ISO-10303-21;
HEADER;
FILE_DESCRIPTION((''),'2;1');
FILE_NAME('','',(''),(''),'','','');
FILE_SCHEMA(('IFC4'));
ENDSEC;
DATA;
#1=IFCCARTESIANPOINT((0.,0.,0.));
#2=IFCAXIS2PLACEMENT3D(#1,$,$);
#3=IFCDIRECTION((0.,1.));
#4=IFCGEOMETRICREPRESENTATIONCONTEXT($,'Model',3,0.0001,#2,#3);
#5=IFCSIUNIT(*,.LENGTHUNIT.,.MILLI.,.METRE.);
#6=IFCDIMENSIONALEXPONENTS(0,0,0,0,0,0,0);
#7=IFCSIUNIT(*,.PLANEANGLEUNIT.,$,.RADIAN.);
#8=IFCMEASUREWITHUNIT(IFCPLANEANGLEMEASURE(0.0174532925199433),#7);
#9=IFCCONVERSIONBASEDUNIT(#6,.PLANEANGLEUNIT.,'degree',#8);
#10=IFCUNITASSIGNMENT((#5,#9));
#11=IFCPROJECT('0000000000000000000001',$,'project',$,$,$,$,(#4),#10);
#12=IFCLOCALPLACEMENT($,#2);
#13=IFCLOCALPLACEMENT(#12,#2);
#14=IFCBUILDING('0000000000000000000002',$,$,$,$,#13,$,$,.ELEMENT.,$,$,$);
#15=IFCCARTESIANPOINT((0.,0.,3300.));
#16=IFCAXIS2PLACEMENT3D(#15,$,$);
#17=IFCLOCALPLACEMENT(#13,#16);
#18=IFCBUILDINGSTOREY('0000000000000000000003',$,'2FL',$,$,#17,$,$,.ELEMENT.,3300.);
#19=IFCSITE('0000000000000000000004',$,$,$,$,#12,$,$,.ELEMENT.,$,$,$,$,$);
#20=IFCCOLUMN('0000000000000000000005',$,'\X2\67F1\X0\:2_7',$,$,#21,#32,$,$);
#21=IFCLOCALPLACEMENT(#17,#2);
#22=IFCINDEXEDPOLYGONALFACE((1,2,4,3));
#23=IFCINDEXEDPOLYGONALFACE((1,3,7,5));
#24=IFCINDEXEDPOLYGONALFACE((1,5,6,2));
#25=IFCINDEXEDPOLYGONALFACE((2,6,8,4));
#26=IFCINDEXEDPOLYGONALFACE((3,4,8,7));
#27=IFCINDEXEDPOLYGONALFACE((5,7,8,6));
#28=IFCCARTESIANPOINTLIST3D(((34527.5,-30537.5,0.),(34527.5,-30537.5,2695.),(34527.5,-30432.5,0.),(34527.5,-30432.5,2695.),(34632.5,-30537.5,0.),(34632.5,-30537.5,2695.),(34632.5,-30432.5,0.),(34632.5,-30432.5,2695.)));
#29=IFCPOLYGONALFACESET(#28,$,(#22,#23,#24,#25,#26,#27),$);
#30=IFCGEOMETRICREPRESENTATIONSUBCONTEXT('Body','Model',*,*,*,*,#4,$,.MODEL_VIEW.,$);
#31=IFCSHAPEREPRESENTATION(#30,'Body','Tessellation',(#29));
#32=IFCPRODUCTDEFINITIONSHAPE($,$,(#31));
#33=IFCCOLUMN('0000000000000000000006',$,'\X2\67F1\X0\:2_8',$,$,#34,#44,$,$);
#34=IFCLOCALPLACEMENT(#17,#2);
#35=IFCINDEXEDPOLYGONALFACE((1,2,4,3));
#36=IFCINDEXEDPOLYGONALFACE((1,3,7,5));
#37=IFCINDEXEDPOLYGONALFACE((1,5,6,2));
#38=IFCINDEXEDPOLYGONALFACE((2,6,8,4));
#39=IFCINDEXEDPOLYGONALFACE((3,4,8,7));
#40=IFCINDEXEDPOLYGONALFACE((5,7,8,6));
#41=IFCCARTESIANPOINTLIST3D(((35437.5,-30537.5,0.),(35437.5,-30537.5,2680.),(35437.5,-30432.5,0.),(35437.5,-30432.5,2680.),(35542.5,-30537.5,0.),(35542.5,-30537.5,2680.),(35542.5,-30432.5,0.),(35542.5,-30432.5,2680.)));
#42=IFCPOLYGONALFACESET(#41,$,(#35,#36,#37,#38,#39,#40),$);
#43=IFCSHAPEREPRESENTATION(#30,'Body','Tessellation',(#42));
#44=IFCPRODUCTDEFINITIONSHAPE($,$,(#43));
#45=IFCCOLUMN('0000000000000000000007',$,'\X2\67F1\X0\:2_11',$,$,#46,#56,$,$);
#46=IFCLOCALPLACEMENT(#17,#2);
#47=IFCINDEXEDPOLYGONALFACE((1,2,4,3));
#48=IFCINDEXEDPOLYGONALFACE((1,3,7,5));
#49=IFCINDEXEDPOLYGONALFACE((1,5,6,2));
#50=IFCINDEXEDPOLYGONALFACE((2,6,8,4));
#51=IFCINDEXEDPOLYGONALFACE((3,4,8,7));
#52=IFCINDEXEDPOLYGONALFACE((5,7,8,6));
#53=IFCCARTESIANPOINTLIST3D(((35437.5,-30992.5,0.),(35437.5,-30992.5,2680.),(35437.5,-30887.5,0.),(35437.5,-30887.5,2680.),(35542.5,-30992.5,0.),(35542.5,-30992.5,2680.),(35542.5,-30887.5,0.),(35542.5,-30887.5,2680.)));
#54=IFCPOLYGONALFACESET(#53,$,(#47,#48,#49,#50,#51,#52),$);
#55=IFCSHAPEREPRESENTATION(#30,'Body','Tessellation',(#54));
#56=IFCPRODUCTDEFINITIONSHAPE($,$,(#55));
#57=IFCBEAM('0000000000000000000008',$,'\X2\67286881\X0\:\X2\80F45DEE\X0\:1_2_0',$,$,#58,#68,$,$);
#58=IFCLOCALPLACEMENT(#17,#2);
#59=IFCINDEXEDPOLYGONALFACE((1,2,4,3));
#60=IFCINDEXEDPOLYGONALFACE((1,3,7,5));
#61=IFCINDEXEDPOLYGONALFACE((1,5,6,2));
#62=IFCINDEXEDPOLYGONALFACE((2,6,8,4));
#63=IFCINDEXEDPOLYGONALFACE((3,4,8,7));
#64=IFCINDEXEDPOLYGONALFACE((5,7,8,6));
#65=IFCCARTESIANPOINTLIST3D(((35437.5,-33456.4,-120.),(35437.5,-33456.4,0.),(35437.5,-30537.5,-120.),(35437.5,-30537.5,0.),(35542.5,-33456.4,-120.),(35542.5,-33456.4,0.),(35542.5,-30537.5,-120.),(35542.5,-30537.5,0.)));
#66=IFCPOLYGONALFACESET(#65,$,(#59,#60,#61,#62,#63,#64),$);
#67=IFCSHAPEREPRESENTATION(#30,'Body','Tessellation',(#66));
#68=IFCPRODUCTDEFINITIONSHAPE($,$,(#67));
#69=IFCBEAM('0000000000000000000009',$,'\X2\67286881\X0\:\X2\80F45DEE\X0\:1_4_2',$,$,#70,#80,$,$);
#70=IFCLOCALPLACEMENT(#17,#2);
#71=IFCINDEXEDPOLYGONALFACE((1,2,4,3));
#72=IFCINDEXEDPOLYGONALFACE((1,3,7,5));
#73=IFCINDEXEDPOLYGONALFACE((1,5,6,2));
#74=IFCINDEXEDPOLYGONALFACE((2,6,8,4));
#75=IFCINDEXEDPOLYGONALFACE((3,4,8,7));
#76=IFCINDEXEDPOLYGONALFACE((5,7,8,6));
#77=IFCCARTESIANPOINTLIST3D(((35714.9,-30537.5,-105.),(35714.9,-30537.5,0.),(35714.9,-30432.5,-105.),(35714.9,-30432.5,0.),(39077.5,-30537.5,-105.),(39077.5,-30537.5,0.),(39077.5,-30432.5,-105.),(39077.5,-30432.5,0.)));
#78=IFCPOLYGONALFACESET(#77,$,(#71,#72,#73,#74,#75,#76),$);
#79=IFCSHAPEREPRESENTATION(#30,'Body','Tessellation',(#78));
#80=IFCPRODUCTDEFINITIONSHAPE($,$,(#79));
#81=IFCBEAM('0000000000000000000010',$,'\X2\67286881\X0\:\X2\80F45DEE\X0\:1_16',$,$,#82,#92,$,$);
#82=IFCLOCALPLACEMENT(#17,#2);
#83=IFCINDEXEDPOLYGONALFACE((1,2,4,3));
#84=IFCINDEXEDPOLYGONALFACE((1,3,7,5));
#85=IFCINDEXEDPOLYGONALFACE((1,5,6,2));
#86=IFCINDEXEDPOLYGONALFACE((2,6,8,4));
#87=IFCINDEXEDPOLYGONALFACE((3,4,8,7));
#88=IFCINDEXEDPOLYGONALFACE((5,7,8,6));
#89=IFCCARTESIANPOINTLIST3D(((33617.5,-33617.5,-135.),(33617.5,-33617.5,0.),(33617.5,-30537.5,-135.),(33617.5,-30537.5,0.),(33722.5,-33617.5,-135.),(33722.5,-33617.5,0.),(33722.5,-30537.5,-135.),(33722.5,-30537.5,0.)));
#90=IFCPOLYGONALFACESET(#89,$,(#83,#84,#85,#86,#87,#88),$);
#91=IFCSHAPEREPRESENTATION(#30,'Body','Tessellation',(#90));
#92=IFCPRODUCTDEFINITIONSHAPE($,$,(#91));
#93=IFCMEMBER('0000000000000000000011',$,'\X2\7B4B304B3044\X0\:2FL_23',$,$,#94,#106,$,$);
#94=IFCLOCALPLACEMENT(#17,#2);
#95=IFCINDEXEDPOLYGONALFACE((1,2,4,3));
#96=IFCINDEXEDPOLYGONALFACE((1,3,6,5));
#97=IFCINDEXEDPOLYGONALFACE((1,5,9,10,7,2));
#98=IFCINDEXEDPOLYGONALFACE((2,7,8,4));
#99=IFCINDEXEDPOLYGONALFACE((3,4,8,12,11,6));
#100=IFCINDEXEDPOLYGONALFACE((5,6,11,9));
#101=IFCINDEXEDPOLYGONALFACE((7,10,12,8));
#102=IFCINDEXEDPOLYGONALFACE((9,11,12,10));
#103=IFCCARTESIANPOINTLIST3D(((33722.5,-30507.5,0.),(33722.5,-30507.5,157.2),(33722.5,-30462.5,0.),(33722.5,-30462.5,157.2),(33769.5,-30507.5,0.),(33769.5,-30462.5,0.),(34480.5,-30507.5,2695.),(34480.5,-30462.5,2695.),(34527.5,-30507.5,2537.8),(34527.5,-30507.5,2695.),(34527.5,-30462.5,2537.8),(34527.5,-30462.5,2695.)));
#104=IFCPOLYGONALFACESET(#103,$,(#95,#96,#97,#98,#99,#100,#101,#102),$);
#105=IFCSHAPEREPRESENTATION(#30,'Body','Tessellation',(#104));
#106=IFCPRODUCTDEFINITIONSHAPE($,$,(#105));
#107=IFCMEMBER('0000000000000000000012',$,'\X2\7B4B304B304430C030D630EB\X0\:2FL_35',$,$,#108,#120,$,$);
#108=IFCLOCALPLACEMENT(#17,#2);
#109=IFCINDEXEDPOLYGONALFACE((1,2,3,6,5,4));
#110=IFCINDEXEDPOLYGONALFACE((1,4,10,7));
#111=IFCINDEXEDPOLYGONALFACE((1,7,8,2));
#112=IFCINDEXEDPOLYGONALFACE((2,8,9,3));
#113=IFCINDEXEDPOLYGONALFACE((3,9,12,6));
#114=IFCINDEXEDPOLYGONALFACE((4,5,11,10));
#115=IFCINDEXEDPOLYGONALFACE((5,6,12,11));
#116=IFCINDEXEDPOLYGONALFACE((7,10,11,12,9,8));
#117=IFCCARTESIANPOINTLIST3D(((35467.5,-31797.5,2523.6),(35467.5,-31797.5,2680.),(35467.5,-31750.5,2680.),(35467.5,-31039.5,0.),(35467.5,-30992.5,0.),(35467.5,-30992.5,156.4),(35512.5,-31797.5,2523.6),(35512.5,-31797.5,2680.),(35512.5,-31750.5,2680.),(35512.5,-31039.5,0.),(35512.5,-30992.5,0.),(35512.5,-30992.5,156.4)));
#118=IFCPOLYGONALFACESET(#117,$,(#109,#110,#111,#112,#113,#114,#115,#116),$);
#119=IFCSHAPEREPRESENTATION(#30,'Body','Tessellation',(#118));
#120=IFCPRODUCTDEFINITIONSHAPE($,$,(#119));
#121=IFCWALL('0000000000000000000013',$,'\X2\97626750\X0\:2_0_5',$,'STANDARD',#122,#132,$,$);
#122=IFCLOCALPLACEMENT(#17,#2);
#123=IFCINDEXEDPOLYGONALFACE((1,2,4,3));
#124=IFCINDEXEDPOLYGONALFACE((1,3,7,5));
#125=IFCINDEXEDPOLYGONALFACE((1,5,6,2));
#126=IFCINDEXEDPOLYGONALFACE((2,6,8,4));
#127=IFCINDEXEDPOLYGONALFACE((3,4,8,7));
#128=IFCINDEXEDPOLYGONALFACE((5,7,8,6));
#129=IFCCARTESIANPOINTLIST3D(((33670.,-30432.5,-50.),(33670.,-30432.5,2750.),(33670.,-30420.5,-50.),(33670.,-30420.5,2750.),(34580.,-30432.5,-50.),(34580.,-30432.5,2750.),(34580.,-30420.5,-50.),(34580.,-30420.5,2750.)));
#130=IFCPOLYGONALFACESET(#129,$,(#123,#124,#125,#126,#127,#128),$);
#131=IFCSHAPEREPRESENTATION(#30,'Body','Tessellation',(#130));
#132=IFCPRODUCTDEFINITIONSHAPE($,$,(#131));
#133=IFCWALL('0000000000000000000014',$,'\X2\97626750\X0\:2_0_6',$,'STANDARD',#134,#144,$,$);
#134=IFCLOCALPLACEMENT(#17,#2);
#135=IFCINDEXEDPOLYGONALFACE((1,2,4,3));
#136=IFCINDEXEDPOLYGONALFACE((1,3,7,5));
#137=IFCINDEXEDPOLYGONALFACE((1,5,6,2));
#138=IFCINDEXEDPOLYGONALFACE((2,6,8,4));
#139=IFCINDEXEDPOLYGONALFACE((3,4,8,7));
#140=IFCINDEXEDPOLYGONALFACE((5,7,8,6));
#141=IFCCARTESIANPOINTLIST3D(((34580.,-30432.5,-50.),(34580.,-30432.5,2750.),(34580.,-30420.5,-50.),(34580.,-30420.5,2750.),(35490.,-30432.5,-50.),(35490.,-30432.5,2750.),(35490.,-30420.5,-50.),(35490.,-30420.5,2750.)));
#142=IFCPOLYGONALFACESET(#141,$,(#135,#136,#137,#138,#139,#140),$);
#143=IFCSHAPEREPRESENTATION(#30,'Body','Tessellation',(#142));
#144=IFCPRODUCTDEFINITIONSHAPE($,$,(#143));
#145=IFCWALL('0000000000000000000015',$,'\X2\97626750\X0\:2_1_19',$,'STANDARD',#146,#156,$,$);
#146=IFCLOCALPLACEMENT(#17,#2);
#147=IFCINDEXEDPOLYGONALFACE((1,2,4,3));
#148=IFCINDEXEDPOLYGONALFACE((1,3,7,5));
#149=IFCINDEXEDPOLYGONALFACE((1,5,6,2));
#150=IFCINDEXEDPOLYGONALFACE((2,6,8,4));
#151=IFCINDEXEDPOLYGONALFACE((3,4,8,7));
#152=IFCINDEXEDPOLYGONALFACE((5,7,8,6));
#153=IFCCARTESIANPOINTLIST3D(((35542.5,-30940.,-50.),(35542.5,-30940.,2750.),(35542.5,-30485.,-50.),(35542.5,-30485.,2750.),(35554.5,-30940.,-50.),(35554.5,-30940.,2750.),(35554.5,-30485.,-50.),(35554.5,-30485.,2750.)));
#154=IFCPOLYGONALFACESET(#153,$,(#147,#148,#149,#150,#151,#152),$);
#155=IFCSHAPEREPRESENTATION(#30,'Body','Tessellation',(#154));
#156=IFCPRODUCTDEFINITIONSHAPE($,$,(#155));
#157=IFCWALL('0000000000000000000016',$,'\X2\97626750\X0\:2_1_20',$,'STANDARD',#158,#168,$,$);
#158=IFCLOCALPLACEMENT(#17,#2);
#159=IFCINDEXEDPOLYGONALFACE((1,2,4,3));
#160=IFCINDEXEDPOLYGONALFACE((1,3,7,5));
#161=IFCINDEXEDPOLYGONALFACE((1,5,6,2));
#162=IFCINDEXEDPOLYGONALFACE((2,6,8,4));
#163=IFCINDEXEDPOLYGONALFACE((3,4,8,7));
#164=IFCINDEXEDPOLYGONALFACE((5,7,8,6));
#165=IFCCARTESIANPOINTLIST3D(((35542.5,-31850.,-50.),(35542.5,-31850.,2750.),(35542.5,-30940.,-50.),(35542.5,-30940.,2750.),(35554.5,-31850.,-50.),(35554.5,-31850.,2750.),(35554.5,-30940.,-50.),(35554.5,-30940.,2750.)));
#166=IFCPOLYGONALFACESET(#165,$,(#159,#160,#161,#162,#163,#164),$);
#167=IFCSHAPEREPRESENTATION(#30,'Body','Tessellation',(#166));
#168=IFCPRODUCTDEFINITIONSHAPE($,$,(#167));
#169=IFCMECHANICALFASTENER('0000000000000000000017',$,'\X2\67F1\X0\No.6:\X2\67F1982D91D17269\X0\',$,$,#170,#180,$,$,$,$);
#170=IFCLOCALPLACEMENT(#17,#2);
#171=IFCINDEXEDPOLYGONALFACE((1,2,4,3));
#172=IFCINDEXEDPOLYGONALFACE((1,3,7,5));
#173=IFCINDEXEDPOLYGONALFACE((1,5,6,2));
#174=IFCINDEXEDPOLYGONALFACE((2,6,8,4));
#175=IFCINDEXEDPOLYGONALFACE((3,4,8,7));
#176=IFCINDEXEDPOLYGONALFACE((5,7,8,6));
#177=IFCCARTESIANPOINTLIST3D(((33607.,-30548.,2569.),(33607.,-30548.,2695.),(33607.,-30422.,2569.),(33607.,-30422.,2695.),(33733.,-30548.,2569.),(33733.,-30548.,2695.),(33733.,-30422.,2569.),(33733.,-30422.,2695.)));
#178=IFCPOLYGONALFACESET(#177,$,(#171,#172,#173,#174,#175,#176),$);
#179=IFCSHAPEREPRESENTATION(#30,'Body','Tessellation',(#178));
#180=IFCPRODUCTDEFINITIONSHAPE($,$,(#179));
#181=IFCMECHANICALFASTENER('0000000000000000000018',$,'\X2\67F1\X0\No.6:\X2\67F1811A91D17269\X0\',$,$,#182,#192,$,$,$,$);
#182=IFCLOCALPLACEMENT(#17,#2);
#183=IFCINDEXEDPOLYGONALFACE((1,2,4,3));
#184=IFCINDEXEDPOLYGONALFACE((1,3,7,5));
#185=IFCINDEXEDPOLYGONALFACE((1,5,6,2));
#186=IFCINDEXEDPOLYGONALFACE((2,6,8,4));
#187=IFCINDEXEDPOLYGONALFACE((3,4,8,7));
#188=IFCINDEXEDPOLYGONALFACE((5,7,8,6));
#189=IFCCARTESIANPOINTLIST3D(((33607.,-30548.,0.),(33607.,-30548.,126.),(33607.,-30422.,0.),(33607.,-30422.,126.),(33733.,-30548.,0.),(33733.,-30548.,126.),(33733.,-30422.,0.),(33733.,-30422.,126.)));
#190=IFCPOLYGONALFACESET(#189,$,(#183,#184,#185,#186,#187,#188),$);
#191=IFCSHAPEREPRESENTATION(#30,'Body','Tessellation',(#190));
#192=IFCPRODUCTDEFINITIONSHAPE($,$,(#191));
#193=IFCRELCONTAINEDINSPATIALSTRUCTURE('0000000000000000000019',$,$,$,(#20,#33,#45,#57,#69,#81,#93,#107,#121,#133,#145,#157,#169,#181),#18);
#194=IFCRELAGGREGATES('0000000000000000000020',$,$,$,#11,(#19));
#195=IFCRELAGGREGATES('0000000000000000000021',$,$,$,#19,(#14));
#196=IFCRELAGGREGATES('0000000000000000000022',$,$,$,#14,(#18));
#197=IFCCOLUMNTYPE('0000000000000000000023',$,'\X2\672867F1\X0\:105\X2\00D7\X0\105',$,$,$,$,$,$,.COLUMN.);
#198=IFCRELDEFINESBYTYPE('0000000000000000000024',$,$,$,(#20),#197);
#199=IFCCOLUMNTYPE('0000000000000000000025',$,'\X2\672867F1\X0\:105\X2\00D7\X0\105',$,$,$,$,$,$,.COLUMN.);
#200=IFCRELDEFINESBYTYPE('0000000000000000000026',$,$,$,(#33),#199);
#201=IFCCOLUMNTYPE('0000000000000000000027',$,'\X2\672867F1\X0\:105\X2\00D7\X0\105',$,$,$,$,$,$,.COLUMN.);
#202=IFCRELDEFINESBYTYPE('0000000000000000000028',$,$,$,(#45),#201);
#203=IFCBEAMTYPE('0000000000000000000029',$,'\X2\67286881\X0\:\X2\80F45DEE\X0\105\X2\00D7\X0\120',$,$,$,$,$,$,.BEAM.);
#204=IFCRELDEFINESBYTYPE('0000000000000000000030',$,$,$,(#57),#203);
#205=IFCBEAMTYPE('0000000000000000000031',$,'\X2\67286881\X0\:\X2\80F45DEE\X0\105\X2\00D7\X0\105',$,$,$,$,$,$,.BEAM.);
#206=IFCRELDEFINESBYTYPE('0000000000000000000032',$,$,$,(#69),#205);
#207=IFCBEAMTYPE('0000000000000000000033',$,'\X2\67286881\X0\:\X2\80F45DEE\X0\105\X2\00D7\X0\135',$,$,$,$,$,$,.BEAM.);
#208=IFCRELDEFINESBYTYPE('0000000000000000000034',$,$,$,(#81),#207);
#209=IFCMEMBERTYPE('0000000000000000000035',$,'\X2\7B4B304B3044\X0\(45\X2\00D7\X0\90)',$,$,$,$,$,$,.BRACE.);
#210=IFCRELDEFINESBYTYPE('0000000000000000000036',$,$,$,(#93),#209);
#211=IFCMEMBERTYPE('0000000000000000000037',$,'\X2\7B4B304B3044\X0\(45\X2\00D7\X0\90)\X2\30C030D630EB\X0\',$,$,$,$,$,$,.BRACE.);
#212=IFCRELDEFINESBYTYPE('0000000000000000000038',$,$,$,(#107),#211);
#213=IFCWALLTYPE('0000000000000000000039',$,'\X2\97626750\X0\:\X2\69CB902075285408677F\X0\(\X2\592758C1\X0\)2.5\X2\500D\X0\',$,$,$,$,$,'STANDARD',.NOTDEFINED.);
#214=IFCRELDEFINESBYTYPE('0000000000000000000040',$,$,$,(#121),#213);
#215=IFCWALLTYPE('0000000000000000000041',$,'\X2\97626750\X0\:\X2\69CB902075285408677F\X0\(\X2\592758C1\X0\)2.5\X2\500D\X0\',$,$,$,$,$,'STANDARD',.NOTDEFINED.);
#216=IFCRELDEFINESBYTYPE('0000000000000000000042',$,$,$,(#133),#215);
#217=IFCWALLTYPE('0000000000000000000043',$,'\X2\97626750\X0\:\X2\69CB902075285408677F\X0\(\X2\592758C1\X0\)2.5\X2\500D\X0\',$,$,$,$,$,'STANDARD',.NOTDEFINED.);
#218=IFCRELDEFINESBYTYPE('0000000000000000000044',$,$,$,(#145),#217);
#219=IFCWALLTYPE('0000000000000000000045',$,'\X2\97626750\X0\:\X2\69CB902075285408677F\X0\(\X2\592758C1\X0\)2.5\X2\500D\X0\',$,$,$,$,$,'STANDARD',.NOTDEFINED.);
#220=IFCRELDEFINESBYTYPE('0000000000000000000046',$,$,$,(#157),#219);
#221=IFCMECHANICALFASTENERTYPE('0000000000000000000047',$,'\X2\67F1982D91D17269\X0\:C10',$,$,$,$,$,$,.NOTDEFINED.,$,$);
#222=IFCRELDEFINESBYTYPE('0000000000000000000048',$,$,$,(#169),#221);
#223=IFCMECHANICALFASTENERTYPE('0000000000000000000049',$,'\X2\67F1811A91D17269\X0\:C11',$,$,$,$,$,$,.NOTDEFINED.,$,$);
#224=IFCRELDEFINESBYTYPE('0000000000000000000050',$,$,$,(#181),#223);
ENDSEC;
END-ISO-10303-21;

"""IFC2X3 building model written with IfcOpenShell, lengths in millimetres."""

from ifc_helpers import new_model, entity, si_unit, converted_unit, direction, frame, origin, origin_with_axes, origin_2d, place, context, subcontext, project, spatial, polyline, rectangle, outline, extrude, type_object, element, save


model = new_model("IFC2X3")

# Units and contexts
model_context = context("Model", 3, precision=0.0001, world=origin(), true_north=direction((0.0, 1.0)))
body_context = subcontext(model_context, "Body", "Model", "MODEL_VIEW")
ifc_project = project(units=[si_unit("LENGTHUNIT", "METRE", prefix="MILLI"), converted_unit("PLANEANGLEUNIT", "degree", entity("IfcPlaneAngleMeasure", 0.0174532925199433), si_unit("PLANEANGLEUNIT", "RADIAN"), dimensions=[0, 0, 0, 0, 0, 0, 0])], contexts=[model_context])

# Site, building, storey
site_placement = place(None, origin())
site = spatial("IfcSite", under=ifc_project, at=site_placement, CompositionType="ELEMENT")
building_placement = place(site_placement, origin())
building = spatial("IfcBuilding", under=site, at=building_placement, CompositionType="ELEMENT")
storey_placement = place(building_placement, frame((0.0, 0.0, 3300.0)))
storey = spatial("IfcBuildingStorey", under=building, at=storey_placement, Name="2FL", CompositionType="ELEMENT", Elevation=3300.0)

# Columns
column_type_1 = type_object("IfcColumnType", Name="木柱:105×105", PredefinedType="COLUMN")
column_1_placement = place(storey_placement, frame((34580.0, -30485.0, 0.0)))
element("IfcColumn", 1, at=column_1_placement, inside=storey, type_object=column_type_1, Name="柱:2_7", context=body_context, shape_type="SweptSolid", body=[
    extrude(rectangle(XDim=105.0, YDim=105.0, at=origin_2d()), origin_with_axes(), (0.0, 0.0, 1.0), 2695.0),
])
column_type_2 = type_object("IfcColumnType", Name="木柱:105×105", PredefinedType="COLUMN")
column_2_placement = place(storey_placement, frame((35490.0, -30485.0, 0.0)))
element("IfcColumn", 2, at=column_2_placement, inside=storey, type_object=column_type_2, Name="柱:2_8", context=body_context, shape_type="SweptSolid", body=[
    extrude(rectangle(XDim=105.0, YDim=105.0, at=origin_2d()), origin_with_axes(), (0.0, 0.0, 1.0), 2680.0),
])
column_type_3 = type_object("IfcColumnType", Name="木柱:105×105", PredefinedType="COLUMN")
column_3_placement = place(storey_placement, frame((35490.0, -30940.0, 0.0)))
element("IfcColumn", 3, at=column_3_placement, inside=storey, type_object=column_type_3, Name="柱:2_11", context=body_context, shape_type="SweptSolid", body=[
    extrude(rectangle(XDim=105.0, YDim=105.0, at=origin_2d()), origin_with_axes(), (0.0, 0.0, 1.0), 2680.0),
])

# Beams
beam_type_1 = type_object("IfcBeamType", Name="木梁:胴差105×120", PredefinedType="BEAM")
beam_1_placement = place(storey_placement, frame((35490.0, -30537.5, -60.0), z_axis=(0.0, -1.0, 0.0), x_axis=(1.0, 0.0, 0.0)))
element("IfcBeam", 4, at=beam_1_placement, inside=storey, type_object=beam_type_1, Name="木梁:胴差:1_2_0", context=body_context, shape_type="SweptSolid", body=[
    extrude(rectangle(XDim=105.0, YDim=120.0, at=origin_2d()), origin_with_axes(), (0.0, 0.0, 1.0), 2918.8),
])
beam_type_2 = type_object("IfcBeamType", Name="木梁:胴差105×105", PredefinedType="BEAM")
beam_2_placement = place(storey_placement, frame((35714.9, -30485.0, -52.5), z_axis=(1.0, 0.0, 0.0), x_axis=(0.0, 1.0, 0.0)))
element("IfcBeam", 5, at=beam_2_placement, inside=storey, type_object=beam_type_2, Name="木梁:胴差:1_4_2", context=body_context, shape_type="SweptSolid", body=[
    extrude(rectangle(XDim=105.0, YDim=105.0, at=origin_2d()), origin_with_axes(), (0.0, 0.0, 1.0), 3362.6),
])
beam_type_3 = type_object("IfcBeamType", Name="木梁:胴差105×135", PredefinedType="BEAM")
beam_3_placement = place(storey_placement, frame((33670.0, -30537.5, -67.5), z_axis=(0.0, -1.0, 0.0), x_axis=(1.0, 0.0, 0.0)))
element("IfcBeam", 6, at=beam_3_placement, inside=storey, type_object=beam_type_3, Name="木梁:胴差:1_16", context=body_context, shape_type="SweptSolid", body=[
    extrude(rectangle(XDim=105.0, YDim=135.0, at=origin_2d()), origin_with_axes(), (0.0, 0.0, 1.0), 3080.0),
])

# Members
member_type_1 = type_object("IfcMemberType", Name="筋かい(45×90)", PredefinedType="BRACE")
member_1_placement = place(storey_placement, frame((33722.5, -30485.0, 0.0), z_axis=(0.286206, 0.0, 0.958168), x_axis=(-0.958168, 0.0, 0.286206)))
element("IfcMember", 7, at=member_1_placement, inside=storey, type_object=member_type_1, Name="筋かい:2FL_23", context=body_context, shape_type="SweptSolid", body=[
    extrude(outline(polyline([(0.0, 0.0), (13.4, -45.0), (2662.0, -45.0), (2812.7, 0.0), (2799.2, 45.0), (150.7, 45.0), (0.0, 0.0)])), frame((0.0, -22.5, 0.0), z_axis=(0.0, 1.0, 0.0), x_axis=(0.0, 0.0, 1.0)), (0.0, 0.0, 1.0), 45.0),
])
member_type_2 = type_object("IfcMemberType", Name="筋かい(45×90)ダブル", PredefinedType="BRACE")
member_2_placement = place(storey_placement, frame((35490.0, -30992.5, 0.0), z_axis=(0.0, -0.287676, 0.957728), x_axis=(0.0, 0.957728, 0.287676)))
element("IfcMember", 8, at=member_2_placement, inside=storey, type_object=member_type_2, Name="筋かいダブル:2FL_35", context=body_context, shape_type="SweptSolid", body=[
    extrude(outline(polyline([(0.0, 0.0), (13.5, -45.0), (2648.5, -45.0), (2798.3, 0.0), (2784.8, 45.0), (149.8, 45.0), (0.0, 0.0)])), frame((0.0, -22.5, 0.0), z_axis=(0.0, 1.0, 0.0), x_axis=(0.0, 0.0, 1.0)), (0.0, 0.0, 1.0), 45.0),
])

# Walls
wall_type_1 = type_object("IfcWallType", Name="面材:構造用合板(大壁)2.5倍", ElementType="STANDARD", PredefinedType="NOTDEFINED")
wall_1_placement = place(storey_placement, frame((34125.0, -30420.5, -50.0), z_axis=(0.0, -1.0, 0.0), x_axis=(1.0, 0.0, 0.0)))
element("IfcWall", 9, at=wall_1_placement, inside=storey, type_object=wall_type_1, Name="面材:2_0_5", ObjectType="STANDARD", context=body_context, shape_type="SweptSolid", body=[
    extrude(outline(polyline([(455.0, 0.0, 0.0), (-455.0, 0.0, 0.0), (-455.0, 2800.0, 0.0), (455.0, 2800.0, 0.0), (455.0, 0.0, 0.0)])), origin_with_axes(), (0.0, 0.0, 1.0), 12.0),
])
wall_type_2 = type_object("IfcWallType", Name="面材:構造用合板(大壁)2.5倍", ElementType="STANDARD", PredefinedType="NOTDEFINED")
wall_2_placement = place(storey_placement, frame((35035.0, -30420.5, -50.0), z_axis=(0.0, -1.0, 0.0), x_axis=(1.0, 0.0, 0.0)))
element("IfcWall", 10, at=wall_2_placement, inside=storey, type_object=wall_type_2, Name="面材:2_0_6", ObjectType="STANDARD", context=body_context, shape_type="SweptSolid", body=[
    extrude(outline(polyline([(455.0, 0.0, 0.0), (-455.0, 0.0, 0.0), (-455.0, 2800.0, 0.0), (455.0, 2800.0, 0.0), (455.0, 0.0, 0.0)])), origin_with_axes(), (0.0, 0.0, 1.0), 12.0),
])
wall_type_3 = type_object("IfcWallType", Name="面材:構造用合板(大壁)2.5倍", ElementType="STANDARD", PredefinedType="NOTDEFINED")
wall_3_placement = place(storey_placement, frame((35554.5, -30712.5, -50.0), z_axis=(-1.0, 0.0, 0.0), x_axis=(0.0, -1.0, 0.0)))
element("IfcWall", 11, at=wall_3_placement, inside=storey, type_object=wall_type_3, Name="面材:2_1_19", ObjectType="STANDARD", context=body_context, shape_type="SweptSolid", body=[
    extrude(outline(polyline([(227.5, 0.0, 0.0), (-227.5, 0.0, 0.0), (-227.5, 2800.0, 0.0), (227.5, 2800.0, 0.0), (227.5, 0.0, 0.0)])), origin_with_axes(), (0.0, 0.0, 1.0), 12.0),
])
wall_type_4 = type_object("IfcWallType", Name="面材:構造用合板(大壁)2.5倍", ElementType="STANDARD", PredefinedType="NOTDEFINED")
wall_4_placement = place(storey_placement, frame((35554.5, -31395.0, -50.0), z_axis=(-1.0, 0.0, 0.0), x_axis=(0.0, -1.0, 0.0)))
element("IfcWall", 12, at=wall_4_placement, inside=storey, type_object=wall_type_4, Name="面材:2_1_20", ObjectType="STANDARD", context=body_context, shape_type="SweptSolid", body=[
    extrude(outline(polyline([(455.0, 0.0, 0.0), (-455.0, 0.0, 0.0), (-455.0, 2800.0, 0.0), (455.0, 2800.0, 0.0), (455.0, 0.0, 0.0)])), origin_with_axes(), (0.0, 0.0, 1.0), 12.0),
])

# Mechanical fasteners
mechanical_fastener_type_1 = type_object("IfcMechanicalFastenerType", Name="柱頭金物:C10")
mechanical_fastener_1_placement = place(storey_placement, frame((33670.0, -30485.0, 2569.0)))
element("IfcMechanicalFastener", 13, at=mechanical_fastener_1_placement, inside=storey, type_object=mechanical_fastener_type_1, Name="柱No.6:柱頭金物", context=body_context, shape_type="SweptSolid", body=[
    extrude(rectangle(XDim=126.0, YDim=126.0, at=origin_2d()), origin_with_axes(), (0.0, 0.0, 1.0), 126.0),
])
mechanical_fastener_type_2 = type_object("IfcMechanicalFastenerType", Name="柱脚金物:C11")
mechanical_fastener_2_placement = place(storey_placement, frame((33670.0, -30485.0, 0.0)))
element("IfcMechanicalFastener", 14, at=mechanical_fastener_2_placement, inside=storey, type_object=mechanical_fastener_type_2, Name="柱No.6:柱脚金物", context=body_context, shape_type="SweptSolid", body=[
    extrude(rectangle(XDim=126.0, YDim=126.0, at=origin_2d()), origin_with_axes(), (0.0, 0.0, 1.0), 126.0),
])

save(model, "model.ifc")
